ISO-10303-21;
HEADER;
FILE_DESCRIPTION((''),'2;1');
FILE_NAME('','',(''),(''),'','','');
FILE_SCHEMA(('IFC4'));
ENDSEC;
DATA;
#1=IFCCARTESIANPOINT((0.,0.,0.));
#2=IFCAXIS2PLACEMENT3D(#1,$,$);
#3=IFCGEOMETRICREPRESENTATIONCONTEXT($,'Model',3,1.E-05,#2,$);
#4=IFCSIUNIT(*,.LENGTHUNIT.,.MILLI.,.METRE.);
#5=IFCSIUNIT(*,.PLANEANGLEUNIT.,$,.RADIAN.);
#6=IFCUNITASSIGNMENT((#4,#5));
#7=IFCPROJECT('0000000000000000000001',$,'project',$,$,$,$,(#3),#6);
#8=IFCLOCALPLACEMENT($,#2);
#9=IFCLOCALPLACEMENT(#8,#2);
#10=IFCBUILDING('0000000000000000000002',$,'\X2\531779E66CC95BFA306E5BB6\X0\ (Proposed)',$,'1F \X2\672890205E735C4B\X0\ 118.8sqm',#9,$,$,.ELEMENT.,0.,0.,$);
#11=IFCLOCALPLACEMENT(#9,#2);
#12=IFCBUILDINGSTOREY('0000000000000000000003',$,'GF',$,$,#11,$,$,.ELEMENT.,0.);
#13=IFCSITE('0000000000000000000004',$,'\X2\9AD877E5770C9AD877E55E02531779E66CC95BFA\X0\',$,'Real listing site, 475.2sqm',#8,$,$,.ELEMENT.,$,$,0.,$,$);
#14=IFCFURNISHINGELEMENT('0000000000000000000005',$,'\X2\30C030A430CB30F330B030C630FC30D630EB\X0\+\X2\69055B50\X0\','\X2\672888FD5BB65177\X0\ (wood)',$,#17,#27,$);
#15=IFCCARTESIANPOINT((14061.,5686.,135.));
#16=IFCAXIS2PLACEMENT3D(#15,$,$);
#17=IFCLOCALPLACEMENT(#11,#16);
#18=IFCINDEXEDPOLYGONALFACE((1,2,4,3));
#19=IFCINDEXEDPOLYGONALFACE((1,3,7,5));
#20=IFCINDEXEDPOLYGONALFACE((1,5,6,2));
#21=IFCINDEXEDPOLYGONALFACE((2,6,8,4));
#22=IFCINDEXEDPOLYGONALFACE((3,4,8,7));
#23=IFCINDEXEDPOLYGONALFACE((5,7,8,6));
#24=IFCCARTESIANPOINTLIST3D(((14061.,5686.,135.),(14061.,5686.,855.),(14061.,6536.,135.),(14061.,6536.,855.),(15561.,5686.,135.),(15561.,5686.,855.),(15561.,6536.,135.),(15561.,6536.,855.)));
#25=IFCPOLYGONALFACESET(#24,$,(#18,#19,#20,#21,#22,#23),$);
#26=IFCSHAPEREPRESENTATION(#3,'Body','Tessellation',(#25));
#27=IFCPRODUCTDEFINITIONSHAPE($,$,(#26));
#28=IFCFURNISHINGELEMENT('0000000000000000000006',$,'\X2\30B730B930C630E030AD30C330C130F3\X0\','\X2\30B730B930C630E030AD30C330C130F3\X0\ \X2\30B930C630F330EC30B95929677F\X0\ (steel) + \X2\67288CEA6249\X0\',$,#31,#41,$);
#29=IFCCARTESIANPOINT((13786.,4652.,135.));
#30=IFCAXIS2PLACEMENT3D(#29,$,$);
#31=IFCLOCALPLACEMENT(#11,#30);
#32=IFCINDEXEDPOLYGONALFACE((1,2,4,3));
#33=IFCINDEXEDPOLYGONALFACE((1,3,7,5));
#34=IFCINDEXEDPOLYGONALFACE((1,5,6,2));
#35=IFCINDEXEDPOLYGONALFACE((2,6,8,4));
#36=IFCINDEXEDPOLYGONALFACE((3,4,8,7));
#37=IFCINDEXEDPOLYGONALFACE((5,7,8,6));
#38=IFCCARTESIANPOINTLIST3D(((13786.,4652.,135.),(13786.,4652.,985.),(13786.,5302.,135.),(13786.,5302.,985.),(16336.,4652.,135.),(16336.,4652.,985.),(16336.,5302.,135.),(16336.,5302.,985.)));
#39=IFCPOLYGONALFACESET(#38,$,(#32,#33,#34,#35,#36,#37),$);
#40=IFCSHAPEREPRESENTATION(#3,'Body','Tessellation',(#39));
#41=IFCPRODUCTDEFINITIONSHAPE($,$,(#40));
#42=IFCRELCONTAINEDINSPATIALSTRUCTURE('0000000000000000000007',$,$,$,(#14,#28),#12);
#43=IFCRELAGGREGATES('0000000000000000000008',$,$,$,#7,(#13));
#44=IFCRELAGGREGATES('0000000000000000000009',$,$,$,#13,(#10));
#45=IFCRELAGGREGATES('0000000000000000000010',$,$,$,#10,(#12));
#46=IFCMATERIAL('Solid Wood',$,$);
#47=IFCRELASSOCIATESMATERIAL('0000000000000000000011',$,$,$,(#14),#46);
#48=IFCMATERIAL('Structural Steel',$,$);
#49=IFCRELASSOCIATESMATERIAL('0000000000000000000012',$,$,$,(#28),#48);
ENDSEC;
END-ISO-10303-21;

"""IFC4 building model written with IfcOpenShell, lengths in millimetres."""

from ifc_helpers import new_model, si_unit, frame, frame_2d, origin, place, context, project, spatial, rectangle, extrude, material, element, save


model = new_model("IFC4")

# Units and contexts
model_context = context("Model", 3, precision=1e-05, world=origin())
ifc_project = project(units=[si_unit("LENGTHUNIT", "METRE", prefix="MILLI"), si_unit("PLANEANGLEUNIT", "RADIAN")], contexts=[model_context])

# Site, building, storey
site_placement = place(None, origin())
site = spatial("IfcSite", under=ifc_project, at=site_placement, Name="高知県高知市北秦泉寺", ObjectType="Real listing site, 475.2sqm", CompositionType="ELEMENT", RefElevation=0.0)
building_placement = place(site_placement, origin())
building = spatial("IfcBuilding", under=site, at=building_placement, Name="北秦泉寺の家 (Proposed)", ObjectType="1F 木造平屋 118.8sqm", CompositionType="ELEMENT", ElevationOfRefHeight=0.0, ElevationOfTerrain=0.0)
storey_placement = place(building_placement, origin())
storey = spatial("IfcBuildingStorey", under=building, at=storey_placement, Name="GF", CompositionType="ELEMENT", Elevation=0.0)

# Shared definitions
ifc_material_1 = material(Name="Solid Wood")

# Shared definitions
ifc_material_2 = material(Name="Structural Steel")

# Furnishing elements
furnishing_1_placement = place(storey_placement, frame((14061.0, 5686.0, 135.0)))
element("IfcFurnishingElement", 1, at=furnishing_1_placement, inside=storey, material=ifc_material_1, Name="ダイニングテーブル+椅子", Description="木製家具 (wood)", context=model_context, shape_type="SweptSolid", body=[
    extrude(rectangle(XDim=1500.0, YDim=850.0, at=frame_2d((750.0, 425.0))), frame((14061.0, 5686.0, 135.0)), (0.0, 0.0, 1.0), 720.0),
])
furnishing_2_placement = place(storey_placement, frame((13786.0, 4652.0, 135.0)))
element("IfcFurnishingElement", 2, at=furnishing_2_placement, inside=storey, material=ifc_material_2, Name="システムキッチン", Description="システムキッチン ステンレス天板 (steel) + 木質扉", context=model_context, shape_type="SweptSolid", body=[
    extrude(rectangle(XDim=2550.0, YDim=650.0, at=frame_2d((1275.0, 325.0))), frame((13786.0, 4652.0, 135.0)), (0.0, 0.0, 1.0), 850.0),
])

save(model, "model.ifc")
